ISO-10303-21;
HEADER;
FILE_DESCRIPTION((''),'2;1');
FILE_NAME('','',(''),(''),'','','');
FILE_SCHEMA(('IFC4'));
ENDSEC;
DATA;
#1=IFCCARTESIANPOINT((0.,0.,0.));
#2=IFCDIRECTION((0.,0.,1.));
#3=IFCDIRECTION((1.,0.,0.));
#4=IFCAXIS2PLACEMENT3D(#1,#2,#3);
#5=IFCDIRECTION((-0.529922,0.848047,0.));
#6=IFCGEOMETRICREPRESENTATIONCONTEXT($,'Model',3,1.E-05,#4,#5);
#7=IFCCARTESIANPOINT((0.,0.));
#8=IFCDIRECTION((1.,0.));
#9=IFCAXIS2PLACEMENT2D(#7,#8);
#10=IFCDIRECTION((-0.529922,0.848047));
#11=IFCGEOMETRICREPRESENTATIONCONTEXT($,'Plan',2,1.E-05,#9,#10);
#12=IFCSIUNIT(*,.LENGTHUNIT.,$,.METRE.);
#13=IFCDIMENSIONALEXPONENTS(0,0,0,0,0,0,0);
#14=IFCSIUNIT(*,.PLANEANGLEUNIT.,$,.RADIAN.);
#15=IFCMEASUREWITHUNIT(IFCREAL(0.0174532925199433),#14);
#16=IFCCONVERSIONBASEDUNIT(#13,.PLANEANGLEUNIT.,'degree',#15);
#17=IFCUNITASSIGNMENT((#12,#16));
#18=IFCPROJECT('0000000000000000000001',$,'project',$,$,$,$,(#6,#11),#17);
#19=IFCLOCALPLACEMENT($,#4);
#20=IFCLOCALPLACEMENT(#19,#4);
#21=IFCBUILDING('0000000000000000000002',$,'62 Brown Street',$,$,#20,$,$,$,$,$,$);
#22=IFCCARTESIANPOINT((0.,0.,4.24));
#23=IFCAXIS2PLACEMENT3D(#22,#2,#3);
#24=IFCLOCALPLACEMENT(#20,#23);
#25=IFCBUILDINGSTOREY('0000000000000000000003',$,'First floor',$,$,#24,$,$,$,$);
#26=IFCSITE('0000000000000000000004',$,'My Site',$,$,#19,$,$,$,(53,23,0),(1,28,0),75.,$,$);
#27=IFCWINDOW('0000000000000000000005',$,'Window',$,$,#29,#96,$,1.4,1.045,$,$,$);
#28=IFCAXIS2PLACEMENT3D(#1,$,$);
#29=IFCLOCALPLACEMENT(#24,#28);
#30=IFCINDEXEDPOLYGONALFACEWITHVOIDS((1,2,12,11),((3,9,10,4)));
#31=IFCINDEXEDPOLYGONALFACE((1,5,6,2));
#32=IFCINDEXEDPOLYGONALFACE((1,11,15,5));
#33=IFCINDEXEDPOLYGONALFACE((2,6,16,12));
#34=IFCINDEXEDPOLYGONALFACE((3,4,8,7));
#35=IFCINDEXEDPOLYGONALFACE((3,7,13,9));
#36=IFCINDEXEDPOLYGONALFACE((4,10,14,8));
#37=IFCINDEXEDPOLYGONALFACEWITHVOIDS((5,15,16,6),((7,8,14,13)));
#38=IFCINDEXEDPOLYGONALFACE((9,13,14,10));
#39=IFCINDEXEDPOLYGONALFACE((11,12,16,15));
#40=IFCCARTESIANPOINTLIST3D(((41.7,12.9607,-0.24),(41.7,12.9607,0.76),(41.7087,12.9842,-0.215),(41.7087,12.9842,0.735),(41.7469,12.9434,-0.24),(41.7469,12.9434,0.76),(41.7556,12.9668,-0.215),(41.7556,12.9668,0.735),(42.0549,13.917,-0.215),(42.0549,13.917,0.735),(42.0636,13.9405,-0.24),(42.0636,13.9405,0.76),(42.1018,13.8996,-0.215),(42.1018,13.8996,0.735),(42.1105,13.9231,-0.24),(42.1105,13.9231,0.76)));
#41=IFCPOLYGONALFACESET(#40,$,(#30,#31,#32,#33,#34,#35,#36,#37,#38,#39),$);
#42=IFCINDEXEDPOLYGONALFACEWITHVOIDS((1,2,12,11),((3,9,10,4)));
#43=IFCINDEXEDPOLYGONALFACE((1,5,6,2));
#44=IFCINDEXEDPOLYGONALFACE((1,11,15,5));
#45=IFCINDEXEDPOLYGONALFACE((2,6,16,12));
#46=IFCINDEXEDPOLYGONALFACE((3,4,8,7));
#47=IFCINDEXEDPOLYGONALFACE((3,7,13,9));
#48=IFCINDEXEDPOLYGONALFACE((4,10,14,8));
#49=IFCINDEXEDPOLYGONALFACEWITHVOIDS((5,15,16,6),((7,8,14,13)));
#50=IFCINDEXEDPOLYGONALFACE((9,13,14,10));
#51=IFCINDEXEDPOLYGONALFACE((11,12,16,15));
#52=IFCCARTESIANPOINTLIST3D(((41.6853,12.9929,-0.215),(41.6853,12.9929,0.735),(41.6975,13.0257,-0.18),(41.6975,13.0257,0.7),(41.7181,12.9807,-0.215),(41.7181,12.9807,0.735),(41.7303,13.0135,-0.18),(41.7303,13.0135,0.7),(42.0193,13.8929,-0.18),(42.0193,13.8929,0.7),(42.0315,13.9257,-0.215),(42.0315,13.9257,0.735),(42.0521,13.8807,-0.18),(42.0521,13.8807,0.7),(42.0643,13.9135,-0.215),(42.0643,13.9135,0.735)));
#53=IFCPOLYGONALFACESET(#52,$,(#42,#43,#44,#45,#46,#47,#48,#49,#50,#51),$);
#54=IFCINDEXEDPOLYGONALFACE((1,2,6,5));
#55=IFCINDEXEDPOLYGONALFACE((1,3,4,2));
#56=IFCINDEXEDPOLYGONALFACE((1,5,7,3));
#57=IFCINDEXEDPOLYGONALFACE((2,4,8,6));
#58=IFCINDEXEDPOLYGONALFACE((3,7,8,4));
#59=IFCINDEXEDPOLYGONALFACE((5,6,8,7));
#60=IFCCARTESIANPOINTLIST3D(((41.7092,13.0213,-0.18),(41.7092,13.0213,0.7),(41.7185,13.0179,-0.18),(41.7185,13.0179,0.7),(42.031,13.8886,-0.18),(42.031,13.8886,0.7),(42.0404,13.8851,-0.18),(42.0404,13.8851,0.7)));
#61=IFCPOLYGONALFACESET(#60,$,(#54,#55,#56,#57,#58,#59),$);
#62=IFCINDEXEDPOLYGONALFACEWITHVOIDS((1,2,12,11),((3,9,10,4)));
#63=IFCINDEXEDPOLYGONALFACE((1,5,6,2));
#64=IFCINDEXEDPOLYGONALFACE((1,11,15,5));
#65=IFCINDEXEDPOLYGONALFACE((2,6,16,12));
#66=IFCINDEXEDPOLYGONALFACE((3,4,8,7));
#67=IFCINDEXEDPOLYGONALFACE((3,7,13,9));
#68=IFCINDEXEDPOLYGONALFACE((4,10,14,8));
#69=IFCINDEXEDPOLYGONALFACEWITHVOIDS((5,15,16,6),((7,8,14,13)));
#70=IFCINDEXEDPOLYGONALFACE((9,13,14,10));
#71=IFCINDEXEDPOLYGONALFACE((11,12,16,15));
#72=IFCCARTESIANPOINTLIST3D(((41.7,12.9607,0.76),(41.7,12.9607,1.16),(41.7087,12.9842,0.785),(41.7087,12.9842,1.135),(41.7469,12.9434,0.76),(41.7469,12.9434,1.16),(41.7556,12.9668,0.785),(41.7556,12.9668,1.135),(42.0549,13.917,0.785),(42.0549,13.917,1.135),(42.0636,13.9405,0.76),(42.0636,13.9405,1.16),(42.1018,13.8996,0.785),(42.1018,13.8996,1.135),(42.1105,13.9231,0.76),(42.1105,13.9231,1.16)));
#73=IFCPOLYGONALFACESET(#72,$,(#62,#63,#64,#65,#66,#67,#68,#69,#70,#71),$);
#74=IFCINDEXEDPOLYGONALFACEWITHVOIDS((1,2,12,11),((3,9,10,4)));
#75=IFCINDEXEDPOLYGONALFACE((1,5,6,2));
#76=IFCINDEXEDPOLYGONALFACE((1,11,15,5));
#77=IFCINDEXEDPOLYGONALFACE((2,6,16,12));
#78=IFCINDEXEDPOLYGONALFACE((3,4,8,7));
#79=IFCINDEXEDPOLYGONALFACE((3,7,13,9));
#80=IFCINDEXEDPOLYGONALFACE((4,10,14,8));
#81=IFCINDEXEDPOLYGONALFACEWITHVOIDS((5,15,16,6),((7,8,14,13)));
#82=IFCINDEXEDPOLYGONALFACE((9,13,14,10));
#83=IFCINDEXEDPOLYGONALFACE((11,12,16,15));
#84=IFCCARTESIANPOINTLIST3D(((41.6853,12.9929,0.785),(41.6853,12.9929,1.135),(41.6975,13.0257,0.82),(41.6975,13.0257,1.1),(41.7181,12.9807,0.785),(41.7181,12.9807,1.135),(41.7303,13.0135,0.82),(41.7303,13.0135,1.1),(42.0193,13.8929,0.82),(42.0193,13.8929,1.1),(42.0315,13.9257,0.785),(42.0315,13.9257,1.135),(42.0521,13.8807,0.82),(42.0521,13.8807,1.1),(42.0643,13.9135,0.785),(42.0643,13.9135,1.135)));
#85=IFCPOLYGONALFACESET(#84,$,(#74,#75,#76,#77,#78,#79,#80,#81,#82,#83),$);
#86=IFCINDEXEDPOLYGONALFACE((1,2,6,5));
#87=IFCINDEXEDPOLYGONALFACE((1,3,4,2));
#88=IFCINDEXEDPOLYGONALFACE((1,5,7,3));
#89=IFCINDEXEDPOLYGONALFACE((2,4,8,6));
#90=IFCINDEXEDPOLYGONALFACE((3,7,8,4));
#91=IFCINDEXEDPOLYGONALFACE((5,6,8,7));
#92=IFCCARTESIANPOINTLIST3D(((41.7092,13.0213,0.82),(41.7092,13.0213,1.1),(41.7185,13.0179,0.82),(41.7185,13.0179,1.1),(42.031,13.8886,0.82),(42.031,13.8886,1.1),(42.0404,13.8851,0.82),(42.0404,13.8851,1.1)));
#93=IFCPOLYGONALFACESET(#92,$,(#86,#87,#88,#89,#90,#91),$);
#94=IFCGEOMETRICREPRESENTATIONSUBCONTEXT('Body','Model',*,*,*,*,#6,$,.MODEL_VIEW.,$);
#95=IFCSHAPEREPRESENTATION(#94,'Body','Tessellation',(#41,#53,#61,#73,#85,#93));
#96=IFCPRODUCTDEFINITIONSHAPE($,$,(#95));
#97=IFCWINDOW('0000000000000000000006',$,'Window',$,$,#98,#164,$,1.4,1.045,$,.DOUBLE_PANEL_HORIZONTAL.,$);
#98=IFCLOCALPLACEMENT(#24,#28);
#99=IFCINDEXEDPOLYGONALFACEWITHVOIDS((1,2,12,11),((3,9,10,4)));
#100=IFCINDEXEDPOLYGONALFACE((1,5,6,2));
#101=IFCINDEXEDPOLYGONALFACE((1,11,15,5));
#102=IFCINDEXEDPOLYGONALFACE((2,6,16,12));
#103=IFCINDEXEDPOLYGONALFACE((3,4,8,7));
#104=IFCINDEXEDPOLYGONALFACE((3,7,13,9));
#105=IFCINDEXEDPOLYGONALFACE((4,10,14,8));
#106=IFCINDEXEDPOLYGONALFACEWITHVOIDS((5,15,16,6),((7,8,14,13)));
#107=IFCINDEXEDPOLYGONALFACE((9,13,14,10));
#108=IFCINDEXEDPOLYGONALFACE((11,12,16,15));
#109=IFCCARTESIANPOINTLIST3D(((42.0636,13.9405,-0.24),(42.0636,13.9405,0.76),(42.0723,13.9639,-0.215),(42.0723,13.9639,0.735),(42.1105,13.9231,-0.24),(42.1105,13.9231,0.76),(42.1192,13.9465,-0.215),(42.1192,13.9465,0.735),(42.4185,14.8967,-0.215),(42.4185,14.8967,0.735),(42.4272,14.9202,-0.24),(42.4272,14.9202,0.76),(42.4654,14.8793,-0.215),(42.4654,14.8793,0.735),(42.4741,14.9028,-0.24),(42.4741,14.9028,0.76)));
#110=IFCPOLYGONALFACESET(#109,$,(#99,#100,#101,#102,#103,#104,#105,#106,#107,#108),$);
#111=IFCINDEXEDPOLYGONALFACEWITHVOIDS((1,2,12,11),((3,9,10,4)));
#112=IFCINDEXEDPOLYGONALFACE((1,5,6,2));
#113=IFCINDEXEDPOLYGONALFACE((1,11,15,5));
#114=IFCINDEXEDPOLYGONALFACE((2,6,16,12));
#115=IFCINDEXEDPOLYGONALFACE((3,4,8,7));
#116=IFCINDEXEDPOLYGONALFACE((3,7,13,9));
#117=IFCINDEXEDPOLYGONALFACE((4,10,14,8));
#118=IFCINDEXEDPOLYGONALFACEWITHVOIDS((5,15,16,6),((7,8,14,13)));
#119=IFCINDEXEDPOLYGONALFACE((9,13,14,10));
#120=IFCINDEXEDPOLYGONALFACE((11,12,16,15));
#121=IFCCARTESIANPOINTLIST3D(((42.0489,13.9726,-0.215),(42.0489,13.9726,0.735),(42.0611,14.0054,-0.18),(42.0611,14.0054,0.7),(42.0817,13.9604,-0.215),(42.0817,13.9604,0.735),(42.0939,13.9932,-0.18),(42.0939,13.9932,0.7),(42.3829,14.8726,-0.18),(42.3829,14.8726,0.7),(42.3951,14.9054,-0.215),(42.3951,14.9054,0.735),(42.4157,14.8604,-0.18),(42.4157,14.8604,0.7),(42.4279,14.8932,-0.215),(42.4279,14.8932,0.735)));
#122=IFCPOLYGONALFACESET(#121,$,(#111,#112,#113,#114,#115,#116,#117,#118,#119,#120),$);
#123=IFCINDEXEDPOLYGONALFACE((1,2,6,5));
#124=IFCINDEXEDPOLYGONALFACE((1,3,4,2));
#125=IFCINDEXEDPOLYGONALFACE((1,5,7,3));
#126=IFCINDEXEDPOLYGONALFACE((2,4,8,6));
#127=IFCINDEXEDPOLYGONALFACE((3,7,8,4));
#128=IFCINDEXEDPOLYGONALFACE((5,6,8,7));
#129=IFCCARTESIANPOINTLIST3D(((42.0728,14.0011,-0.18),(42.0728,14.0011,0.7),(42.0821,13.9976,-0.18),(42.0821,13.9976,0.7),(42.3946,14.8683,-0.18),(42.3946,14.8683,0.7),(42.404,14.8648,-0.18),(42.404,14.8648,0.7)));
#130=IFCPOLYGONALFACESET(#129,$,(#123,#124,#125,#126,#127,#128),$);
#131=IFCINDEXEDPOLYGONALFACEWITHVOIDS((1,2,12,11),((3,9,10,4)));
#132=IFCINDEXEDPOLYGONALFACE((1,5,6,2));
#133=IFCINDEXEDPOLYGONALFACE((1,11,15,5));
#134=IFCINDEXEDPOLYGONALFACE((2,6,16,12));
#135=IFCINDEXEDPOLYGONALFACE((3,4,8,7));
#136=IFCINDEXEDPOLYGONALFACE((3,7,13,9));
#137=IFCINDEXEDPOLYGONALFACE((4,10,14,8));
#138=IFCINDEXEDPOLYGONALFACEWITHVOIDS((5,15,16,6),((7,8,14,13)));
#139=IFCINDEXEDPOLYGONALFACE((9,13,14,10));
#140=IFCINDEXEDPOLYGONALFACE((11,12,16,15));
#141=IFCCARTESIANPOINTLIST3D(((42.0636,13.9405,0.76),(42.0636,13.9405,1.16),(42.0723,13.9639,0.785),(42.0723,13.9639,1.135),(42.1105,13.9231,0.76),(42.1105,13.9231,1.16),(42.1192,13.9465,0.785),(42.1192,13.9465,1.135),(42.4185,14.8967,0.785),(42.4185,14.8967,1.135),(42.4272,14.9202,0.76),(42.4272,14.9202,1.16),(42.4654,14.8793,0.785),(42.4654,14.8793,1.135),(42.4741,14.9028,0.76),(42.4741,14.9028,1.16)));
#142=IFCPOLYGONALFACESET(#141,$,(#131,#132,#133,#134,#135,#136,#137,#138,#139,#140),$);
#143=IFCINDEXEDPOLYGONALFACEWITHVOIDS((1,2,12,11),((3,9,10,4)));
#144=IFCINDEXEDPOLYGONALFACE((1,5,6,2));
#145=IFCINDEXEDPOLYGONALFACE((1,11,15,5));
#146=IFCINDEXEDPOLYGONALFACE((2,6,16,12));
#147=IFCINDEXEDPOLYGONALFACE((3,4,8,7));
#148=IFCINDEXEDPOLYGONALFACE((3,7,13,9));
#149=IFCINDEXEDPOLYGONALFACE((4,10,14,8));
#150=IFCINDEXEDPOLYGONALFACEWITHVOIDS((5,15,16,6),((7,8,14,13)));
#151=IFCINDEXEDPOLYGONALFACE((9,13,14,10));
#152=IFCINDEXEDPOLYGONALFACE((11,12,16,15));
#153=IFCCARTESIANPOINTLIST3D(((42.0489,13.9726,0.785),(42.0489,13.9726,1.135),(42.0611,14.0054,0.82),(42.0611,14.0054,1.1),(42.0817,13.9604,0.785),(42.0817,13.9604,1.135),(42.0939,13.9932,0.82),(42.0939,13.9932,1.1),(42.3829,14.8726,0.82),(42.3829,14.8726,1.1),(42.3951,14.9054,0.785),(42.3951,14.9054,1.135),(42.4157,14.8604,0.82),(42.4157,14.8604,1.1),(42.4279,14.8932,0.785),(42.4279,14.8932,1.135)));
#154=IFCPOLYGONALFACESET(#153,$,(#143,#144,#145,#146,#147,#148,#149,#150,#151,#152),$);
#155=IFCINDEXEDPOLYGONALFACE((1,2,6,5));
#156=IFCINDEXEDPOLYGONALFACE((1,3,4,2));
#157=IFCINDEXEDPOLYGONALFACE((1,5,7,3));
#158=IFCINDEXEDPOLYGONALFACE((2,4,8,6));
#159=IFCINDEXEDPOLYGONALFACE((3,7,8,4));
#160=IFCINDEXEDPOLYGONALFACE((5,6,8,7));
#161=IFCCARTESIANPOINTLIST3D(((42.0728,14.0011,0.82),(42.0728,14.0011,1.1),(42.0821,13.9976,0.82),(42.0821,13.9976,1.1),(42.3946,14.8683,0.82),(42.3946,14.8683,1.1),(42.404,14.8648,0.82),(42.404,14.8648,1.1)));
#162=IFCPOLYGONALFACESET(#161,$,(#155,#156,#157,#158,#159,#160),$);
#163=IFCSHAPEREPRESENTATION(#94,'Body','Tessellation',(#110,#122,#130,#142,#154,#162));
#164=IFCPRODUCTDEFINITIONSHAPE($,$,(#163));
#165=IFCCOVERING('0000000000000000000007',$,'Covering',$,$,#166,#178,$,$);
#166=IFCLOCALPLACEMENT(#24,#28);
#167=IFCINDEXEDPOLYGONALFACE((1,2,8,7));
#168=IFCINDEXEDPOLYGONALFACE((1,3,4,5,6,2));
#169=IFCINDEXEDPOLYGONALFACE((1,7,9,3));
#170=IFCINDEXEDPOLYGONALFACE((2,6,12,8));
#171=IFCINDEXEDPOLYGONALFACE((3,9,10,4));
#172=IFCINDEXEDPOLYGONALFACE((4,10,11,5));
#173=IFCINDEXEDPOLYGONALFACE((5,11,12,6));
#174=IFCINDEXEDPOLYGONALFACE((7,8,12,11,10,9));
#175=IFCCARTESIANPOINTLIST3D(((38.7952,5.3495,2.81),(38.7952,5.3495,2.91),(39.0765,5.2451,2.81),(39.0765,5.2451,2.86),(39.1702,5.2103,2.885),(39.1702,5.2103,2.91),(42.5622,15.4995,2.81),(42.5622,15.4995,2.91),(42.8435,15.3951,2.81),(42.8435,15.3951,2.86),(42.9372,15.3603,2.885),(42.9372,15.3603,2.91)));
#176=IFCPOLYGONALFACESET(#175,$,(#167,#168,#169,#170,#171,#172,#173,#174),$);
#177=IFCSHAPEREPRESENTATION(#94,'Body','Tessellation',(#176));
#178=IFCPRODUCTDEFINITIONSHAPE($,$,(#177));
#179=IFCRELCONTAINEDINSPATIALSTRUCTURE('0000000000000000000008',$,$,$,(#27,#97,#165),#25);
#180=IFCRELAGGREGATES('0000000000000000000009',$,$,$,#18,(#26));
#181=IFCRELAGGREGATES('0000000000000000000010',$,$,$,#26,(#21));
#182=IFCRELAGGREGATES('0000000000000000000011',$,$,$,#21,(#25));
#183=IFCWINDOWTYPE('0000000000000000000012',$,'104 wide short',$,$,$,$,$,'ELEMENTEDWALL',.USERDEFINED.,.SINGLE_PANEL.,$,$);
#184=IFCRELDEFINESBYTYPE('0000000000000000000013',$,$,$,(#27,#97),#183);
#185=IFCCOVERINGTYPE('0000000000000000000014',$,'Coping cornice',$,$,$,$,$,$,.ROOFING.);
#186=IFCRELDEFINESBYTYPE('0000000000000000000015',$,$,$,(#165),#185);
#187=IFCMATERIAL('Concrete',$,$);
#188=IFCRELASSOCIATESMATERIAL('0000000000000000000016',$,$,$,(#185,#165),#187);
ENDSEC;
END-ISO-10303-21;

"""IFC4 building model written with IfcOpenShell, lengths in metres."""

from ifc_helpers import new_model, entity, si_unit, converted_unit, direction, frame, origin_with_axes, origin_2d_with_axis, place, context, subcontext, project, spatial, line, indexed_curve, outline, extrude, shape, source, transform, mapped, material, material_profile, profile_set, profile_usage, type_object, type_shapes, element, save


model = new_model("IFC4")

# Units and contexts
model_context = context("Model", 3, precision=1e-05, world=origin_with_axes(), true_north=direction((-0.529922, 0.848047, 0.0)))
plan_context = context("Plan", 2, precision=1e-05, world=origin_2d_with_axis(), true_north=direction((-0.529922, 0.848047)))
body_context_1 = subcontext(model_context, "Body", "Model", "MODEL_VIEW")
body_context_2 = subcontext(plan_context, "Body", "Plan", "PLAN_VIEW")
ifc_project = project(units=[si_unit("LENGTHUNIT", "METRE"), converted_unit("PLANEANGLEUNIT", "degree", entity("IfcReal", 0.0174532925199433), si_unit("PLANEANGLEUNIT", "RADIAN"), dimensions=[0, 0, 0, 0, 0, 0, 0])], contexts=[model_context, plan_context])

# Site, building, storey
site_placement = place(None, origin_with_axes())
site = spatial("IfcSite", under=ifc_project, at=site_placement, Name="My Site", RefLatitude=(53, 23, 0), RefLongitude=(1, 28, 0), RefElevation=75.0)
building_placement = place(site_placement, origin_with_axes())
building = spatial("IfcBuilding", under=site, at=building_placement, Name="62 Brown Street")
storey_placement = place(building_placement, frame((0.0, 0.0, 4.24), z_axis=(0.0, 0.0, 1.0), x_axis=(1.0, 0.0, 0.0)))
storey = spatial("IfcBuildingStorey", under=building, at=storey_placement, Name="First floor")

# Shared definitions
window_type = type_object("IfcWindowType", Name="104 wide short", ElementType="ELEMENTEDWALL", PartitioningType="SINGLE_PANEL", PredefinedType="USERDEFINED")
shared_shape_1 = source(origin_with_axes(), body_context_1, "Body", "SweptSolid", [
    extrude(outline(indexed_curve([(0.0, 0.0), (1.045, 0.0), (1.045, 1.0), (0.0, 1.0)], segments=[line(1, 2, 3, 4, 1)]), holes=[indexed_curve([(0.025, 0.025), (1.02, 0.025), (1.02, 0.975), (0.025, 0.975)], segments=[line(1, 2, 3, 4, 1)])]), frame((0.0, 0.15, 0.0), z_axis=(0.0, -1.0, 0.0), x_axis=(1.0, 0.0, 0.0)), (0.0, 0.0, -1.0), 0.05),
    extrude(outline(indexed_curve([(0.0, 0.0), (0.995, 0.0), (0.995, 0.95), (0.0, 0.95)], segments=[line(1, 2, 3, 4, 1)]), holes=[indexed_curve([(0.035, 0.035), (0.96, 0.035), (0.96, 0.915), (0.035, 0.915)], segments=[line(1, 2, 3, 4, 1)])]), frame((0.025, 0.19, 0.025), z_axis=(0.0, -1.0, 0.0), x_axis=(1.0, 0.0, 0.0)), (0.0, 0.0, -1.0), 0.035),
    extrude(outline(indexed_curve([(0.035, 0.035), (0.96, 0.035), (0.96, 0.915), (0.035, 0.915)], segments=[line(1, 2, 3, 4, 1)])), frame((0.025, 0.2025, 0.025), z_axis=(0.0, -1.0, 0.0), x_axis=(1.0, 0.0, 0.0)), (0.0, 0.0, -1.0), 0.01),
    extrude(outline(indexed_curve([(0.0, 0.0), (1.045, 0.0), (1.045, 0.4), (0.0, 0.4)], segments=[line(1, 2, 3, 4, 1)]), holes=[indexed_curve([(0.025, 0.025), (1.02, 0.025), (1.02, 0.375), (0.025, 0.375)], segments=[line(1, 2, 3, 4, 1)])]), frame((0.0, 0.15, 1.0), z_axis=(0.0, -1.0, 0.0), x_axis=(1.0, 0.0, 0.0)), (0.0, 0.0, -1.0), 0.05),
    extrude(outline(indexed_curve([(0.0, 0.0), (0.995, 0.0), (0.995, 0.35), (0.0, 0.35)], segments=[line(1, 2, 3, 4, 1)]), holes=[indexed_curve([(0.035, 0.035), (0.96, 0.035), (0.96, 0.315), (0.035, 0.315)], segments=[line(1, 2, 3, 4, 1)])]), frame((0.025, 0.19, 1.025), z_axis=(0.0, -1.0, 0.0), x_axis=(1.0, 0.0, 0.0)), (0.0, 0.0, -1.0), 0.035),
    extrude(outline(indexed_curve([(0.035, 0.035), (0.96, 0.035), (0.96, 0.315), (0.035, 0.315)], segments=[line(1, 2, 3, 4, 1)])), frame((0.025, 0.2025, 1.025), z_axis=(0.0, -1.0, 0.0), x_axis=(1.0, 0.0, 0.0)), (0.0, 0.0, -1.0), 0.01),
])
shared_shape_2 = source(origin_with_axes(), body_context_2, "Body", "Curve2D", [
    entity("IfcIndexedPolyCurve", entity("IfcCartesianPointList2D", [[0.025, 0.15], [1.02, 0.15]])),
    entity("IfcIndexedPolyCurve", entity("IfcCartesianPointList2D", [[0.0, 0.2], [0.025, 0.2], [0.025, 0.15], [0.0, 0.15]]), [entity("IfcLineIndex", [1, 2, 3, 4, 1])]),
    entity("IfcIndexedPolyCurve", entity("IfcCartesianPointList2D", [[1.045, 0.2], [1.02, 0.2], [1.02, 0.15], [1.045, 0.15]]), [entity("IfcLineIndex", [1, 2, 3, 4, 1])]),
    entity("IfcIndexedPolyCurve", entity("IfcCartesianPointList2D", [[0.025, 0.19], [0.06, 0.19], [0.06, 0.225], [0.025, 0.225]]), [entity("IfcLineIndex", [1, 2, 3, 4, 1])]),
    entity("IfcIndexedPolyCurve", entity("IfcCartesianPointList2D", [[1.02, 0.19], [0.985, 0.19], [0.985, 0.225], [1.02, 0.225]]), [entity("IfcLineIndex", [1, 2, 3, 4, 1])]),
    entity("IfcIndexedPolyCurve", entity("IfcCartesianPointList2D", [[0.06, 0.19], [0.985, 0.19]])),
    entity("IfcIndexedPolyCurve", entity("IfcCartesianPointList2D", [[0.06, 0.225], [0.985, 0.225]])),
    entity("IfcIndexedPolyCurve", entity("IfcCartesianPointList2D", [[0.06, 0.2075], [0.985, 0.2075]])),
])
type_shapes(window_type, [shared_shape_1, shared_shape_2])

# Windows
for number, where, z_axis, x_axis, name in (
    (1, (41.8875, 12.8912, -0.24), (0.0, 0.0, 1.0), (0.347944, 0.937515, 0.0), "Window"),
):
    element("IfcWindow", number, at=place(storey_placement, frame(where, z_axis=z_axis, x_axis=x_axis)), inside=storey, type_object=window_type, Name=name, OverallHeight=1.4, OverallWidth=1.045, shapes=[
        shape(body_context_1, "Body", "MappedRepresentation", [mapped(shared_shape_1, transform((0.0, 0.0, 0.0), x_axis=(1.0, 0.0, 0.0), y_axis=(0.0, 1.0, 0.0), z_axis=(0.0, 0.0, 1.0), scale=1.0))]),
        shape(body_context_2, "Body", "MappedRepresentation", [mapped(shared_shape_2, transform((0.0, 0.0, 0.0), x_axis=(1.0, 0.0, 0.0), y_axis=(0.0, 1.0, 0.0), z_axis=(0.0, 0.0, 1.0), scale=1.0))]),
    ])
window_1_placement = place(storey_placement, frame((42.2511, 13.8709, -0.24), z_axis=(0.0, 0.0, 1.0), x_axis=(0.347944, 0.937515, 0.0)))
element("IfcWindow", 2, at=window_1_placement, inside=storey, type_object=window_type, Name="Window", OverallHeight=1.4, OverallWidth=1.045, PartitioningType="DOUBLE_PANEL_HORIZONTAL", shapes=[
    shape(body_context_1, "Body", "MappedRepresentation", [mapped(shared_shape_1, transform((0.0, 0.0, 0.0), x_axis=(1.0, 0.0, 0.0), y_axis=(0.0, 1.0, 0.0), z_axis=(0.0, 0.0, 1.0), scale=1.0))]),
    shape(body_context_2, "Body", "MappedRepresentation", [mapped(shared_shape_2, transform((0.0, 0.0, 0.0), x_axis=(1.0, 0.0, 0.0), y_axis=(0.0, 1.0, 0.0), z_axis=(0.0, 0.0, 1.0), scale=1.0))]),
])

# Covering
ifc_material_1 = material(Name="Concrete")
ifc_material_profile = material_profile(ifc_material_1, outline(indexed_curve([(-0.2, 0.1), (0.2, 0.1), (0.2, 0.075), (0.1, 0.05), (0.1, 0.0), (-0.2, 0.0)], segments=[line(5, 4), line(4, 3), line(3, 2), line(2, 1), line(1, 6), line(6, 5)], self_intersect=False)))
ifc_profile_set = profile_set([ifc_material_profile], Name="cornice")
ifc_profile_usage = profile_usage(ifc_profile_set, cardinal=5)
covering_type = type_object("IfcCoveringType", Name="Coping cornice", PredefinedType="ROOFING", material=ifc_profile_set)
covering_placement = place(storey_placement, frame((42.7497, 15.4299, 2.81), z_axis=(-0.347944, -0.937515, 0.0), x_axis=(0.937515, -0.347944, 0.0)))
element("IfcCovering", 3, at=covering_placement, inside=storey, type_object=covering_type, material=ifc_profile_usage, Name="Covering", context=body_context_1, shape_type="SweptSolid", body=[
    extrude(outline(indexed_curve([(-0.2, 0.1), (0.2, 0.1), (0.2, 0.075), (0.1, 0.05), (0.1, 0.0), (-0.2, 0.0)], segments=[line(5, 4), line(4, 3), line(3, 2), line(2, 1), line(1, 6), line(6, 5)], self_intersect=False)), origin_with_axes(), (0.0, 0.0, 1.0), 10.8265),
])

save(model, "model.ifc")
